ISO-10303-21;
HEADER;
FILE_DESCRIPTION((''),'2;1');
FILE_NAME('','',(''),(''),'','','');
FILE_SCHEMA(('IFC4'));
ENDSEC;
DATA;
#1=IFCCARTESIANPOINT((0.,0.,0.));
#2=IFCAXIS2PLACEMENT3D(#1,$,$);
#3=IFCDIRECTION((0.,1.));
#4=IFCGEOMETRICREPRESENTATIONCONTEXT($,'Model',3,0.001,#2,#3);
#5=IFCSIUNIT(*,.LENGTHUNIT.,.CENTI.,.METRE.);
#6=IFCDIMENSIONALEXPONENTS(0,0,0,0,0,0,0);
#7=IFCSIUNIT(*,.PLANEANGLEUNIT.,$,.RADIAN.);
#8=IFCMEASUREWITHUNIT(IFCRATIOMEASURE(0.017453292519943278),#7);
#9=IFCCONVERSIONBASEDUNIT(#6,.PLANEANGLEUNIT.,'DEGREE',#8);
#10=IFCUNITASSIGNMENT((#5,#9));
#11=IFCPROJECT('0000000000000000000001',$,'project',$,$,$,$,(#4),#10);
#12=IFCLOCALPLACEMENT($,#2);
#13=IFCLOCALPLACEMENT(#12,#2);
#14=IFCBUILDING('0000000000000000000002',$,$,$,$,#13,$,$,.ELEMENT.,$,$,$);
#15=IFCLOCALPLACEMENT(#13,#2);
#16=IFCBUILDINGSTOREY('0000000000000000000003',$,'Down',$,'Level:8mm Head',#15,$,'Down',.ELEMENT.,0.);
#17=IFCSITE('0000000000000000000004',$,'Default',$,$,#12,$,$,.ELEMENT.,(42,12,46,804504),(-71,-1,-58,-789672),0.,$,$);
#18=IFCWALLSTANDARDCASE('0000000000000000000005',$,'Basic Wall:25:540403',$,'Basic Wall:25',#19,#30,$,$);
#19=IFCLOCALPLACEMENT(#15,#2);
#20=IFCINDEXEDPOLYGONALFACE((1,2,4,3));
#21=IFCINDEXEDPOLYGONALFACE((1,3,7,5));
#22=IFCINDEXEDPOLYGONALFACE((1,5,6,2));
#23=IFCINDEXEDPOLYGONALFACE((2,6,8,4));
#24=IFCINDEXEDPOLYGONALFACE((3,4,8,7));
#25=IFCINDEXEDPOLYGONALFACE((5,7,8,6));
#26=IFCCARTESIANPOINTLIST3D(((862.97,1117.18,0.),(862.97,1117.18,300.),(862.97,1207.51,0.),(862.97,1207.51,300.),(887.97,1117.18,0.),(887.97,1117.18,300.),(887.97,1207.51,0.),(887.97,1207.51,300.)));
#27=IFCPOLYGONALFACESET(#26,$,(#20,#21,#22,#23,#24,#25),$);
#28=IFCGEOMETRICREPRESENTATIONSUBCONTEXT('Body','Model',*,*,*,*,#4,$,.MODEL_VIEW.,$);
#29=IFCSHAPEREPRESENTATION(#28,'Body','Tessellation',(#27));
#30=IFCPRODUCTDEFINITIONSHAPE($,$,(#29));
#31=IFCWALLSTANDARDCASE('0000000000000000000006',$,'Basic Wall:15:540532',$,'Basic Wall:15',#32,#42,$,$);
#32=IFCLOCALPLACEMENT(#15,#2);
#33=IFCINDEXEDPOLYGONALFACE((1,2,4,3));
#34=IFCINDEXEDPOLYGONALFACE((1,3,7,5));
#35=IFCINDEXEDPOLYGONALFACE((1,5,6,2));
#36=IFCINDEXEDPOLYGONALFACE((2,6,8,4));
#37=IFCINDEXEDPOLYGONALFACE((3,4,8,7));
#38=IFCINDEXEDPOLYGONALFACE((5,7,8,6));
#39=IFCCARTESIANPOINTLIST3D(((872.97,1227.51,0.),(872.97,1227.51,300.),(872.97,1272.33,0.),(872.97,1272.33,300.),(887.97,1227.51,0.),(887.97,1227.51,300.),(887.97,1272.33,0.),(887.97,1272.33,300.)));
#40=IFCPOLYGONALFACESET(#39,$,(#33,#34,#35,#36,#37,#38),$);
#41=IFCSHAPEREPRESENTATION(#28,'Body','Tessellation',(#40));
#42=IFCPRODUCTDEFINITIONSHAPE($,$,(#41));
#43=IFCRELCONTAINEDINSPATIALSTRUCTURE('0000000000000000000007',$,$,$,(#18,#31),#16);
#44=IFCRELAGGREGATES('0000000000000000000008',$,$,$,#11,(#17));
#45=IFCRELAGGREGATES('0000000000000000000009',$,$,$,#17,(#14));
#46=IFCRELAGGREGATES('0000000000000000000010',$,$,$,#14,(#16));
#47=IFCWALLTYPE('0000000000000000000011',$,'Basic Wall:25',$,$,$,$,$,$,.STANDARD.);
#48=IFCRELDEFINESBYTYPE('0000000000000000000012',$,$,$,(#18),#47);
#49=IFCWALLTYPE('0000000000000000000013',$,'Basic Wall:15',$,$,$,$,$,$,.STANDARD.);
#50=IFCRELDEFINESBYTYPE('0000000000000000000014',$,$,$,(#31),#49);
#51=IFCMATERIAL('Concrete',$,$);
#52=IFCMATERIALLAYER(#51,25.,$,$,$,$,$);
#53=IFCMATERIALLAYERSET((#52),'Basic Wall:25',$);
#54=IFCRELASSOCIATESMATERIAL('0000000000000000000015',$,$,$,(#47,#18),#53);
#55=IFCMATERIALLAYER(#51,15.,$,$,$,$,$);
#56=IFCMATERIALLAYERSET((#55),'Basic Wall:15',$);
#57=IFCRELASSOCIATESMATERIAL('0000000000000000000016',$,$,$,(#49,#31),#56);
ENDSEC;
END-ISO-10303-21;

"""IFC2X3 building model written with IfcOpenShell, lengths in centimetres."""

from ifc_helpers import new_model, entity, si_unit, converted_unit, direction, frame, frame_2d, origin, place, context, subcontext, project, spatial, rectangle, extrude, material, layer, layer_set, layer_usage, type_object, element, save


model = new_model("IFC2X3")

# Units and contexts
model_context = context("Model", 3, precision=0.001, world=origin(), true_north=direction((0.0, 1.0)))
body_context = subcontext(model_context, "Body", "Model", "MODEL_VIEW")
ifc_project = project(units=[si_unit("LENGTHUNIT", "METRE", prefix="CENTI"), converted_unit("PLANEANGLEUNIT", "DEGREE", entity("IfcRatioMeasure", 0.017453292519943278), si_unit("PLANEANGLEUNIT", "RADIAN"), dimensions=[0, 0, 0, 0, 0, 0, 0])], contexts=[model_context])

# Site, building, storey
site_placement = place(None, origin())
site = spatial("IfcSite", under=ifc_project, at=site_placement, Name="Default", CompositionType="ELEMENT", RefLatitude=(42, 12, 46, 804504), RefLongitude=(-71, -1, -58, -789672), RefElevation=0.0)
building_placement = place(site_placement, origin())
building = spatial("IfcBuilding", under=site, at=building_placement, CompositionType="ELEMENT")
storey_placement = place(building_placement, origin())
storey = spatial("IfcBuildingStorey", under=building, at=storey_placement, Name="Down", ObjectType="Level:8mm Head", LongName="Down", CompositionType="ELEMENT", Elevation=0.0)

# Walls
ifc_material = material(Name="Concrete")
ifc_layer_1 = layer(ifc_material, 25.0)
ifc_layer_set_1 = layer_set([ifc_layer_1], Name="Basic Wall:25")
ifc_layer_usage_1 = layer_usage(ifc_layer_set_1, "AXIS2", "NEGATIVE", 12.5)
wall_type_1 = type_object("IfcWallType", Name="Basic Wall:25", PredefinedType="STANDARD", material=ifc_layer_set_1)
wall_1_placement = place(storey_placement, frame((875.47, 1117.18, 0.0), z_axis=(0.0, 0.0, 1.0), x_axis=(0.0, 1.0, 0.0)))
element("IfcWallStandardCase", 1, at=wall_1_placement, inside=storey, type_object=wall_type_1, material=ifc_layer_usage_1, Name="Basic Wall:25:540403", ObjectType="Basic Wall:25", context=body_context, shape_type="SweptSolid", body=[
    extrude(rectangle(XDim=90.33, YDim=25.0, at=frame_2d((45.16, 0.0), x_axis=(-1.0, 0.0))), origin(), (0.0, 0.0, 1.0), 300.0),
])
ifc_layer_2 = layer(ifc_material, 15.0)
ifc_layer_set_2 = layer_set([ifc_layer_2], Name="Basic Wall:15")
ifc_layer_usage_2 = layer_usage(ifc_layer_set_2, "AXIS2", "NEGATIVE", 7.5)
wall_type_2 = type_object("IfcWallType", Name="Basic Wall:15", PredefinedType="STANDARD", material=ifc_layer_set_2)
wall_2_placement = place(storey_placement, frame((880.47, 1272.33, 0.0), z_axis=(0.0, 0.0, 1.0), x_axis=(0.0, -1.0, 0.0)))
element("IfcWallStandardCase", 2, at=wall_2_placement, inside=storey, type_object=wall_type_2, material=ifc_layer_usage_2, Name="Basic Wall:15:540532", ObjectType="Basic Wall:15", context=body_context, shape_type="SweptSolid", body=[
    extrude(rectangle(XDim=44.82, YDim=15.0, at=frame_2d((22.41, 0.0), x_axis=(-1.0, 0.0))), origin(), (0.0, 0.0, 1.0), 300.0),
])

save(model, "model.ifc")
